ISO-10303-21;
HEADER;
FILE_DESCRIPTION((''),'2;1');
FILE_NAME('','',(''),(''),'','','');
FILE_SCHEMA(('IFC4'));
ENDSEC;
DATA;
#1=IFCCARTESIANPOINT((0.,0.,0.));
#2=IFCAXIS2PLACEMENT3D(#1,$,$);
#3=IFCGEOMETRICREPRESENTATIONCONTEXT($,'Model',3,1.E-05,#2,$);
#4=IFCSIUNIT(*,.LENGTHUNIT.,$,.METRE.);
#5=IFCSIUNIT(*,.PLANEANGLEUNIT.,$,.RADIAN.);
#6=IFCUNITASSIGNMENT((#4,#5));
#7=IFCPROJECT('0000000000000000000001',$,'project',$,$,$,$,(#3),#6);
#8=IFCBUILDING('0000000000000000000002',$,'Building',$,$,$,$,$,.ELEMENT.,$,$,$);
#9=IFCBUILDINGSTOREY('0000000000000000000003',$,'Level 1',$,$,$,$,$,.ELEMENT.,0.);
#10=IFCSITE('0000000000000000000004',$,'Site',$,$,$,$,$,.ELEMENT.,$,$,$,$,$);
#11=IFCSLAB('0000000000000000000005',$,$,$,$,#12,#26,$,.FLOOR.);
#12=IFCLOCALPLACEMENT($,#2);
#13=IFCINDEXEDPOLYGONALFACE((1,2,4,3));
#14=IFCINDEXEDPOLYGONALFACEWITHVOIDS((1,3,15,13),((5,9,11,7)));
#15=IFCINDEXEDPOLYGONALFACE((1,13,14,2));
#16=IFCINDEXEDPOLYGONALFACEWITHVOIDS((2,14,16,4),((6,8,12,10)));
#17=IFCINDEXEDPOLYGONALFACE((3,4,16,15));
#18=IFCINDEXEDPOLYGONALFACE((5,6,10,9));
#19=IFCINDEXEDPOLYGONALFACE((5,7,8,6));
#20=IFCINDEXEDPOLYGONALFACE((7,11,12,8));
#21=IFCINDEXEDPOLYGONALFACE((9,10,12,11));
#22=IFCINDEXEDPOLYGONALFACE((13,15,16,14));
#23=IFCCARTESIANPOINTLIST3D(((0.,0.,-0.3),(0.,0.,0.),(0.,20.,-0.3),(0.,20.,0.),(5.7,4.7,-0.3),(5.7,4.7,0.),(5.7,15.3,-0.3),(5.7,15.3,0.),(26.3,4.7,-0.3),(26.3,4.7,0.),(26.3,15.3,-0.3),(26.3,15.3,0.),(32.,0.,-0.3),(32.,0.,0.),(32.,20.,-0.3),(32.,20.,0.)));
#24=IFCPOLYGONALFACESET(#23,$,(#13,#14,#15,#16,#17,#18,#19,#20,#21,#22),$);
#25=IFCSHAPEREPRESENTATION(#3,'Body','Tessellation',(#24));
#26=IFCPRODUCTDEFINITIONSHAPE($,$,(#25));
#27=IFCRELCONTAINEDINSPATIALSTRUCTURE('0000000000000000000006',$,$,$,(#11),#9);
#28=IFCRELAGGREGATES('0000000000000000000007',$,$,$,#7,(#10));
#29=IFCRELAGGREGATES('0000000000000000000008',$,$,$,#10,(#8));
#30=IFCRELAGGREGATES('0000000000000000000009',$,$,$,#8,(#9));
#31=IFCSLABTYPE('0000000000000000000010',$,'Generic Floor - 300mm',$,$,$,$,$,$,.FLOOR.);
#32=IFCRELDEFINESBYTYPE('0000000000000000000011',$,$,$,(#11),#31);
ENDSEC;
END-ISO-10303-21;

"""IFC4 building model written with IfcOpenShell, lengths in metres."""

from ifc_helpers import new_model, si_unit, frame, origin, place, context, project, spatial, polyline, outline, extrude, type_object, element, save


model = new_model("IFC4")

# Units and contexts
model_context = context("Model", 3, precision=1e-05, world=origin())
ifc_project = project(units=[si_unit("LENGTHUNIT", "METRE"), si_unit("PLANEANGLEUNIT", "RADIAN")], contexts=[model_context])

# Site, building, storey
site = spatial("IfcSite", under=ifc_project, Name="Site", CompositionType="ELEMENT")
building = spatial("IfcBuilding", under=site, Name="Building", CompositionType="ELEMENT")
storey = spatial("IfcBuildingStorey", under=building, Name="Level 1", CompositionType="ELEMENT", Elevation=0.0)

# Slab, opening
slab_type = type_object("IfcSlabType", Name="Generic Floor - 300mm", PredefinedType="FLOOR")
slab_placement = place(None, origin())
slab = element("IfcSlab", 1, at=slab_placement, inside=storey, type_object=slab_type, PredefinedType="FLOOR", context=model_context, shape_type="SweptSolid", body=[
    extrude(outline(polyline([(0.0, 0.0), (32.0, 0.0), (32.0, 20.0), (0.0, 20.0), (0.0, 0.0)])), origin(), (0.0, 0.0, -1.0), 0.3),
])
opening_placement = place(None, frame((0.0, 0.0, 0.001)))
element("IfcOpeningElement", 2, at=opening_placement, cuts=slab, PredefinedType="OPENING", context=model_context, shape_type="SweptSolid", body=[
    extrude(outline(polyline([(5.7, 15.3), (5.7, 4.7), (26.3, 4.7), (26.3, 15.3), (5.7, 15.3)])), origin(), (0.0, 0.0, -1.0), 0.302),
])

save(model, "model.ifc")
